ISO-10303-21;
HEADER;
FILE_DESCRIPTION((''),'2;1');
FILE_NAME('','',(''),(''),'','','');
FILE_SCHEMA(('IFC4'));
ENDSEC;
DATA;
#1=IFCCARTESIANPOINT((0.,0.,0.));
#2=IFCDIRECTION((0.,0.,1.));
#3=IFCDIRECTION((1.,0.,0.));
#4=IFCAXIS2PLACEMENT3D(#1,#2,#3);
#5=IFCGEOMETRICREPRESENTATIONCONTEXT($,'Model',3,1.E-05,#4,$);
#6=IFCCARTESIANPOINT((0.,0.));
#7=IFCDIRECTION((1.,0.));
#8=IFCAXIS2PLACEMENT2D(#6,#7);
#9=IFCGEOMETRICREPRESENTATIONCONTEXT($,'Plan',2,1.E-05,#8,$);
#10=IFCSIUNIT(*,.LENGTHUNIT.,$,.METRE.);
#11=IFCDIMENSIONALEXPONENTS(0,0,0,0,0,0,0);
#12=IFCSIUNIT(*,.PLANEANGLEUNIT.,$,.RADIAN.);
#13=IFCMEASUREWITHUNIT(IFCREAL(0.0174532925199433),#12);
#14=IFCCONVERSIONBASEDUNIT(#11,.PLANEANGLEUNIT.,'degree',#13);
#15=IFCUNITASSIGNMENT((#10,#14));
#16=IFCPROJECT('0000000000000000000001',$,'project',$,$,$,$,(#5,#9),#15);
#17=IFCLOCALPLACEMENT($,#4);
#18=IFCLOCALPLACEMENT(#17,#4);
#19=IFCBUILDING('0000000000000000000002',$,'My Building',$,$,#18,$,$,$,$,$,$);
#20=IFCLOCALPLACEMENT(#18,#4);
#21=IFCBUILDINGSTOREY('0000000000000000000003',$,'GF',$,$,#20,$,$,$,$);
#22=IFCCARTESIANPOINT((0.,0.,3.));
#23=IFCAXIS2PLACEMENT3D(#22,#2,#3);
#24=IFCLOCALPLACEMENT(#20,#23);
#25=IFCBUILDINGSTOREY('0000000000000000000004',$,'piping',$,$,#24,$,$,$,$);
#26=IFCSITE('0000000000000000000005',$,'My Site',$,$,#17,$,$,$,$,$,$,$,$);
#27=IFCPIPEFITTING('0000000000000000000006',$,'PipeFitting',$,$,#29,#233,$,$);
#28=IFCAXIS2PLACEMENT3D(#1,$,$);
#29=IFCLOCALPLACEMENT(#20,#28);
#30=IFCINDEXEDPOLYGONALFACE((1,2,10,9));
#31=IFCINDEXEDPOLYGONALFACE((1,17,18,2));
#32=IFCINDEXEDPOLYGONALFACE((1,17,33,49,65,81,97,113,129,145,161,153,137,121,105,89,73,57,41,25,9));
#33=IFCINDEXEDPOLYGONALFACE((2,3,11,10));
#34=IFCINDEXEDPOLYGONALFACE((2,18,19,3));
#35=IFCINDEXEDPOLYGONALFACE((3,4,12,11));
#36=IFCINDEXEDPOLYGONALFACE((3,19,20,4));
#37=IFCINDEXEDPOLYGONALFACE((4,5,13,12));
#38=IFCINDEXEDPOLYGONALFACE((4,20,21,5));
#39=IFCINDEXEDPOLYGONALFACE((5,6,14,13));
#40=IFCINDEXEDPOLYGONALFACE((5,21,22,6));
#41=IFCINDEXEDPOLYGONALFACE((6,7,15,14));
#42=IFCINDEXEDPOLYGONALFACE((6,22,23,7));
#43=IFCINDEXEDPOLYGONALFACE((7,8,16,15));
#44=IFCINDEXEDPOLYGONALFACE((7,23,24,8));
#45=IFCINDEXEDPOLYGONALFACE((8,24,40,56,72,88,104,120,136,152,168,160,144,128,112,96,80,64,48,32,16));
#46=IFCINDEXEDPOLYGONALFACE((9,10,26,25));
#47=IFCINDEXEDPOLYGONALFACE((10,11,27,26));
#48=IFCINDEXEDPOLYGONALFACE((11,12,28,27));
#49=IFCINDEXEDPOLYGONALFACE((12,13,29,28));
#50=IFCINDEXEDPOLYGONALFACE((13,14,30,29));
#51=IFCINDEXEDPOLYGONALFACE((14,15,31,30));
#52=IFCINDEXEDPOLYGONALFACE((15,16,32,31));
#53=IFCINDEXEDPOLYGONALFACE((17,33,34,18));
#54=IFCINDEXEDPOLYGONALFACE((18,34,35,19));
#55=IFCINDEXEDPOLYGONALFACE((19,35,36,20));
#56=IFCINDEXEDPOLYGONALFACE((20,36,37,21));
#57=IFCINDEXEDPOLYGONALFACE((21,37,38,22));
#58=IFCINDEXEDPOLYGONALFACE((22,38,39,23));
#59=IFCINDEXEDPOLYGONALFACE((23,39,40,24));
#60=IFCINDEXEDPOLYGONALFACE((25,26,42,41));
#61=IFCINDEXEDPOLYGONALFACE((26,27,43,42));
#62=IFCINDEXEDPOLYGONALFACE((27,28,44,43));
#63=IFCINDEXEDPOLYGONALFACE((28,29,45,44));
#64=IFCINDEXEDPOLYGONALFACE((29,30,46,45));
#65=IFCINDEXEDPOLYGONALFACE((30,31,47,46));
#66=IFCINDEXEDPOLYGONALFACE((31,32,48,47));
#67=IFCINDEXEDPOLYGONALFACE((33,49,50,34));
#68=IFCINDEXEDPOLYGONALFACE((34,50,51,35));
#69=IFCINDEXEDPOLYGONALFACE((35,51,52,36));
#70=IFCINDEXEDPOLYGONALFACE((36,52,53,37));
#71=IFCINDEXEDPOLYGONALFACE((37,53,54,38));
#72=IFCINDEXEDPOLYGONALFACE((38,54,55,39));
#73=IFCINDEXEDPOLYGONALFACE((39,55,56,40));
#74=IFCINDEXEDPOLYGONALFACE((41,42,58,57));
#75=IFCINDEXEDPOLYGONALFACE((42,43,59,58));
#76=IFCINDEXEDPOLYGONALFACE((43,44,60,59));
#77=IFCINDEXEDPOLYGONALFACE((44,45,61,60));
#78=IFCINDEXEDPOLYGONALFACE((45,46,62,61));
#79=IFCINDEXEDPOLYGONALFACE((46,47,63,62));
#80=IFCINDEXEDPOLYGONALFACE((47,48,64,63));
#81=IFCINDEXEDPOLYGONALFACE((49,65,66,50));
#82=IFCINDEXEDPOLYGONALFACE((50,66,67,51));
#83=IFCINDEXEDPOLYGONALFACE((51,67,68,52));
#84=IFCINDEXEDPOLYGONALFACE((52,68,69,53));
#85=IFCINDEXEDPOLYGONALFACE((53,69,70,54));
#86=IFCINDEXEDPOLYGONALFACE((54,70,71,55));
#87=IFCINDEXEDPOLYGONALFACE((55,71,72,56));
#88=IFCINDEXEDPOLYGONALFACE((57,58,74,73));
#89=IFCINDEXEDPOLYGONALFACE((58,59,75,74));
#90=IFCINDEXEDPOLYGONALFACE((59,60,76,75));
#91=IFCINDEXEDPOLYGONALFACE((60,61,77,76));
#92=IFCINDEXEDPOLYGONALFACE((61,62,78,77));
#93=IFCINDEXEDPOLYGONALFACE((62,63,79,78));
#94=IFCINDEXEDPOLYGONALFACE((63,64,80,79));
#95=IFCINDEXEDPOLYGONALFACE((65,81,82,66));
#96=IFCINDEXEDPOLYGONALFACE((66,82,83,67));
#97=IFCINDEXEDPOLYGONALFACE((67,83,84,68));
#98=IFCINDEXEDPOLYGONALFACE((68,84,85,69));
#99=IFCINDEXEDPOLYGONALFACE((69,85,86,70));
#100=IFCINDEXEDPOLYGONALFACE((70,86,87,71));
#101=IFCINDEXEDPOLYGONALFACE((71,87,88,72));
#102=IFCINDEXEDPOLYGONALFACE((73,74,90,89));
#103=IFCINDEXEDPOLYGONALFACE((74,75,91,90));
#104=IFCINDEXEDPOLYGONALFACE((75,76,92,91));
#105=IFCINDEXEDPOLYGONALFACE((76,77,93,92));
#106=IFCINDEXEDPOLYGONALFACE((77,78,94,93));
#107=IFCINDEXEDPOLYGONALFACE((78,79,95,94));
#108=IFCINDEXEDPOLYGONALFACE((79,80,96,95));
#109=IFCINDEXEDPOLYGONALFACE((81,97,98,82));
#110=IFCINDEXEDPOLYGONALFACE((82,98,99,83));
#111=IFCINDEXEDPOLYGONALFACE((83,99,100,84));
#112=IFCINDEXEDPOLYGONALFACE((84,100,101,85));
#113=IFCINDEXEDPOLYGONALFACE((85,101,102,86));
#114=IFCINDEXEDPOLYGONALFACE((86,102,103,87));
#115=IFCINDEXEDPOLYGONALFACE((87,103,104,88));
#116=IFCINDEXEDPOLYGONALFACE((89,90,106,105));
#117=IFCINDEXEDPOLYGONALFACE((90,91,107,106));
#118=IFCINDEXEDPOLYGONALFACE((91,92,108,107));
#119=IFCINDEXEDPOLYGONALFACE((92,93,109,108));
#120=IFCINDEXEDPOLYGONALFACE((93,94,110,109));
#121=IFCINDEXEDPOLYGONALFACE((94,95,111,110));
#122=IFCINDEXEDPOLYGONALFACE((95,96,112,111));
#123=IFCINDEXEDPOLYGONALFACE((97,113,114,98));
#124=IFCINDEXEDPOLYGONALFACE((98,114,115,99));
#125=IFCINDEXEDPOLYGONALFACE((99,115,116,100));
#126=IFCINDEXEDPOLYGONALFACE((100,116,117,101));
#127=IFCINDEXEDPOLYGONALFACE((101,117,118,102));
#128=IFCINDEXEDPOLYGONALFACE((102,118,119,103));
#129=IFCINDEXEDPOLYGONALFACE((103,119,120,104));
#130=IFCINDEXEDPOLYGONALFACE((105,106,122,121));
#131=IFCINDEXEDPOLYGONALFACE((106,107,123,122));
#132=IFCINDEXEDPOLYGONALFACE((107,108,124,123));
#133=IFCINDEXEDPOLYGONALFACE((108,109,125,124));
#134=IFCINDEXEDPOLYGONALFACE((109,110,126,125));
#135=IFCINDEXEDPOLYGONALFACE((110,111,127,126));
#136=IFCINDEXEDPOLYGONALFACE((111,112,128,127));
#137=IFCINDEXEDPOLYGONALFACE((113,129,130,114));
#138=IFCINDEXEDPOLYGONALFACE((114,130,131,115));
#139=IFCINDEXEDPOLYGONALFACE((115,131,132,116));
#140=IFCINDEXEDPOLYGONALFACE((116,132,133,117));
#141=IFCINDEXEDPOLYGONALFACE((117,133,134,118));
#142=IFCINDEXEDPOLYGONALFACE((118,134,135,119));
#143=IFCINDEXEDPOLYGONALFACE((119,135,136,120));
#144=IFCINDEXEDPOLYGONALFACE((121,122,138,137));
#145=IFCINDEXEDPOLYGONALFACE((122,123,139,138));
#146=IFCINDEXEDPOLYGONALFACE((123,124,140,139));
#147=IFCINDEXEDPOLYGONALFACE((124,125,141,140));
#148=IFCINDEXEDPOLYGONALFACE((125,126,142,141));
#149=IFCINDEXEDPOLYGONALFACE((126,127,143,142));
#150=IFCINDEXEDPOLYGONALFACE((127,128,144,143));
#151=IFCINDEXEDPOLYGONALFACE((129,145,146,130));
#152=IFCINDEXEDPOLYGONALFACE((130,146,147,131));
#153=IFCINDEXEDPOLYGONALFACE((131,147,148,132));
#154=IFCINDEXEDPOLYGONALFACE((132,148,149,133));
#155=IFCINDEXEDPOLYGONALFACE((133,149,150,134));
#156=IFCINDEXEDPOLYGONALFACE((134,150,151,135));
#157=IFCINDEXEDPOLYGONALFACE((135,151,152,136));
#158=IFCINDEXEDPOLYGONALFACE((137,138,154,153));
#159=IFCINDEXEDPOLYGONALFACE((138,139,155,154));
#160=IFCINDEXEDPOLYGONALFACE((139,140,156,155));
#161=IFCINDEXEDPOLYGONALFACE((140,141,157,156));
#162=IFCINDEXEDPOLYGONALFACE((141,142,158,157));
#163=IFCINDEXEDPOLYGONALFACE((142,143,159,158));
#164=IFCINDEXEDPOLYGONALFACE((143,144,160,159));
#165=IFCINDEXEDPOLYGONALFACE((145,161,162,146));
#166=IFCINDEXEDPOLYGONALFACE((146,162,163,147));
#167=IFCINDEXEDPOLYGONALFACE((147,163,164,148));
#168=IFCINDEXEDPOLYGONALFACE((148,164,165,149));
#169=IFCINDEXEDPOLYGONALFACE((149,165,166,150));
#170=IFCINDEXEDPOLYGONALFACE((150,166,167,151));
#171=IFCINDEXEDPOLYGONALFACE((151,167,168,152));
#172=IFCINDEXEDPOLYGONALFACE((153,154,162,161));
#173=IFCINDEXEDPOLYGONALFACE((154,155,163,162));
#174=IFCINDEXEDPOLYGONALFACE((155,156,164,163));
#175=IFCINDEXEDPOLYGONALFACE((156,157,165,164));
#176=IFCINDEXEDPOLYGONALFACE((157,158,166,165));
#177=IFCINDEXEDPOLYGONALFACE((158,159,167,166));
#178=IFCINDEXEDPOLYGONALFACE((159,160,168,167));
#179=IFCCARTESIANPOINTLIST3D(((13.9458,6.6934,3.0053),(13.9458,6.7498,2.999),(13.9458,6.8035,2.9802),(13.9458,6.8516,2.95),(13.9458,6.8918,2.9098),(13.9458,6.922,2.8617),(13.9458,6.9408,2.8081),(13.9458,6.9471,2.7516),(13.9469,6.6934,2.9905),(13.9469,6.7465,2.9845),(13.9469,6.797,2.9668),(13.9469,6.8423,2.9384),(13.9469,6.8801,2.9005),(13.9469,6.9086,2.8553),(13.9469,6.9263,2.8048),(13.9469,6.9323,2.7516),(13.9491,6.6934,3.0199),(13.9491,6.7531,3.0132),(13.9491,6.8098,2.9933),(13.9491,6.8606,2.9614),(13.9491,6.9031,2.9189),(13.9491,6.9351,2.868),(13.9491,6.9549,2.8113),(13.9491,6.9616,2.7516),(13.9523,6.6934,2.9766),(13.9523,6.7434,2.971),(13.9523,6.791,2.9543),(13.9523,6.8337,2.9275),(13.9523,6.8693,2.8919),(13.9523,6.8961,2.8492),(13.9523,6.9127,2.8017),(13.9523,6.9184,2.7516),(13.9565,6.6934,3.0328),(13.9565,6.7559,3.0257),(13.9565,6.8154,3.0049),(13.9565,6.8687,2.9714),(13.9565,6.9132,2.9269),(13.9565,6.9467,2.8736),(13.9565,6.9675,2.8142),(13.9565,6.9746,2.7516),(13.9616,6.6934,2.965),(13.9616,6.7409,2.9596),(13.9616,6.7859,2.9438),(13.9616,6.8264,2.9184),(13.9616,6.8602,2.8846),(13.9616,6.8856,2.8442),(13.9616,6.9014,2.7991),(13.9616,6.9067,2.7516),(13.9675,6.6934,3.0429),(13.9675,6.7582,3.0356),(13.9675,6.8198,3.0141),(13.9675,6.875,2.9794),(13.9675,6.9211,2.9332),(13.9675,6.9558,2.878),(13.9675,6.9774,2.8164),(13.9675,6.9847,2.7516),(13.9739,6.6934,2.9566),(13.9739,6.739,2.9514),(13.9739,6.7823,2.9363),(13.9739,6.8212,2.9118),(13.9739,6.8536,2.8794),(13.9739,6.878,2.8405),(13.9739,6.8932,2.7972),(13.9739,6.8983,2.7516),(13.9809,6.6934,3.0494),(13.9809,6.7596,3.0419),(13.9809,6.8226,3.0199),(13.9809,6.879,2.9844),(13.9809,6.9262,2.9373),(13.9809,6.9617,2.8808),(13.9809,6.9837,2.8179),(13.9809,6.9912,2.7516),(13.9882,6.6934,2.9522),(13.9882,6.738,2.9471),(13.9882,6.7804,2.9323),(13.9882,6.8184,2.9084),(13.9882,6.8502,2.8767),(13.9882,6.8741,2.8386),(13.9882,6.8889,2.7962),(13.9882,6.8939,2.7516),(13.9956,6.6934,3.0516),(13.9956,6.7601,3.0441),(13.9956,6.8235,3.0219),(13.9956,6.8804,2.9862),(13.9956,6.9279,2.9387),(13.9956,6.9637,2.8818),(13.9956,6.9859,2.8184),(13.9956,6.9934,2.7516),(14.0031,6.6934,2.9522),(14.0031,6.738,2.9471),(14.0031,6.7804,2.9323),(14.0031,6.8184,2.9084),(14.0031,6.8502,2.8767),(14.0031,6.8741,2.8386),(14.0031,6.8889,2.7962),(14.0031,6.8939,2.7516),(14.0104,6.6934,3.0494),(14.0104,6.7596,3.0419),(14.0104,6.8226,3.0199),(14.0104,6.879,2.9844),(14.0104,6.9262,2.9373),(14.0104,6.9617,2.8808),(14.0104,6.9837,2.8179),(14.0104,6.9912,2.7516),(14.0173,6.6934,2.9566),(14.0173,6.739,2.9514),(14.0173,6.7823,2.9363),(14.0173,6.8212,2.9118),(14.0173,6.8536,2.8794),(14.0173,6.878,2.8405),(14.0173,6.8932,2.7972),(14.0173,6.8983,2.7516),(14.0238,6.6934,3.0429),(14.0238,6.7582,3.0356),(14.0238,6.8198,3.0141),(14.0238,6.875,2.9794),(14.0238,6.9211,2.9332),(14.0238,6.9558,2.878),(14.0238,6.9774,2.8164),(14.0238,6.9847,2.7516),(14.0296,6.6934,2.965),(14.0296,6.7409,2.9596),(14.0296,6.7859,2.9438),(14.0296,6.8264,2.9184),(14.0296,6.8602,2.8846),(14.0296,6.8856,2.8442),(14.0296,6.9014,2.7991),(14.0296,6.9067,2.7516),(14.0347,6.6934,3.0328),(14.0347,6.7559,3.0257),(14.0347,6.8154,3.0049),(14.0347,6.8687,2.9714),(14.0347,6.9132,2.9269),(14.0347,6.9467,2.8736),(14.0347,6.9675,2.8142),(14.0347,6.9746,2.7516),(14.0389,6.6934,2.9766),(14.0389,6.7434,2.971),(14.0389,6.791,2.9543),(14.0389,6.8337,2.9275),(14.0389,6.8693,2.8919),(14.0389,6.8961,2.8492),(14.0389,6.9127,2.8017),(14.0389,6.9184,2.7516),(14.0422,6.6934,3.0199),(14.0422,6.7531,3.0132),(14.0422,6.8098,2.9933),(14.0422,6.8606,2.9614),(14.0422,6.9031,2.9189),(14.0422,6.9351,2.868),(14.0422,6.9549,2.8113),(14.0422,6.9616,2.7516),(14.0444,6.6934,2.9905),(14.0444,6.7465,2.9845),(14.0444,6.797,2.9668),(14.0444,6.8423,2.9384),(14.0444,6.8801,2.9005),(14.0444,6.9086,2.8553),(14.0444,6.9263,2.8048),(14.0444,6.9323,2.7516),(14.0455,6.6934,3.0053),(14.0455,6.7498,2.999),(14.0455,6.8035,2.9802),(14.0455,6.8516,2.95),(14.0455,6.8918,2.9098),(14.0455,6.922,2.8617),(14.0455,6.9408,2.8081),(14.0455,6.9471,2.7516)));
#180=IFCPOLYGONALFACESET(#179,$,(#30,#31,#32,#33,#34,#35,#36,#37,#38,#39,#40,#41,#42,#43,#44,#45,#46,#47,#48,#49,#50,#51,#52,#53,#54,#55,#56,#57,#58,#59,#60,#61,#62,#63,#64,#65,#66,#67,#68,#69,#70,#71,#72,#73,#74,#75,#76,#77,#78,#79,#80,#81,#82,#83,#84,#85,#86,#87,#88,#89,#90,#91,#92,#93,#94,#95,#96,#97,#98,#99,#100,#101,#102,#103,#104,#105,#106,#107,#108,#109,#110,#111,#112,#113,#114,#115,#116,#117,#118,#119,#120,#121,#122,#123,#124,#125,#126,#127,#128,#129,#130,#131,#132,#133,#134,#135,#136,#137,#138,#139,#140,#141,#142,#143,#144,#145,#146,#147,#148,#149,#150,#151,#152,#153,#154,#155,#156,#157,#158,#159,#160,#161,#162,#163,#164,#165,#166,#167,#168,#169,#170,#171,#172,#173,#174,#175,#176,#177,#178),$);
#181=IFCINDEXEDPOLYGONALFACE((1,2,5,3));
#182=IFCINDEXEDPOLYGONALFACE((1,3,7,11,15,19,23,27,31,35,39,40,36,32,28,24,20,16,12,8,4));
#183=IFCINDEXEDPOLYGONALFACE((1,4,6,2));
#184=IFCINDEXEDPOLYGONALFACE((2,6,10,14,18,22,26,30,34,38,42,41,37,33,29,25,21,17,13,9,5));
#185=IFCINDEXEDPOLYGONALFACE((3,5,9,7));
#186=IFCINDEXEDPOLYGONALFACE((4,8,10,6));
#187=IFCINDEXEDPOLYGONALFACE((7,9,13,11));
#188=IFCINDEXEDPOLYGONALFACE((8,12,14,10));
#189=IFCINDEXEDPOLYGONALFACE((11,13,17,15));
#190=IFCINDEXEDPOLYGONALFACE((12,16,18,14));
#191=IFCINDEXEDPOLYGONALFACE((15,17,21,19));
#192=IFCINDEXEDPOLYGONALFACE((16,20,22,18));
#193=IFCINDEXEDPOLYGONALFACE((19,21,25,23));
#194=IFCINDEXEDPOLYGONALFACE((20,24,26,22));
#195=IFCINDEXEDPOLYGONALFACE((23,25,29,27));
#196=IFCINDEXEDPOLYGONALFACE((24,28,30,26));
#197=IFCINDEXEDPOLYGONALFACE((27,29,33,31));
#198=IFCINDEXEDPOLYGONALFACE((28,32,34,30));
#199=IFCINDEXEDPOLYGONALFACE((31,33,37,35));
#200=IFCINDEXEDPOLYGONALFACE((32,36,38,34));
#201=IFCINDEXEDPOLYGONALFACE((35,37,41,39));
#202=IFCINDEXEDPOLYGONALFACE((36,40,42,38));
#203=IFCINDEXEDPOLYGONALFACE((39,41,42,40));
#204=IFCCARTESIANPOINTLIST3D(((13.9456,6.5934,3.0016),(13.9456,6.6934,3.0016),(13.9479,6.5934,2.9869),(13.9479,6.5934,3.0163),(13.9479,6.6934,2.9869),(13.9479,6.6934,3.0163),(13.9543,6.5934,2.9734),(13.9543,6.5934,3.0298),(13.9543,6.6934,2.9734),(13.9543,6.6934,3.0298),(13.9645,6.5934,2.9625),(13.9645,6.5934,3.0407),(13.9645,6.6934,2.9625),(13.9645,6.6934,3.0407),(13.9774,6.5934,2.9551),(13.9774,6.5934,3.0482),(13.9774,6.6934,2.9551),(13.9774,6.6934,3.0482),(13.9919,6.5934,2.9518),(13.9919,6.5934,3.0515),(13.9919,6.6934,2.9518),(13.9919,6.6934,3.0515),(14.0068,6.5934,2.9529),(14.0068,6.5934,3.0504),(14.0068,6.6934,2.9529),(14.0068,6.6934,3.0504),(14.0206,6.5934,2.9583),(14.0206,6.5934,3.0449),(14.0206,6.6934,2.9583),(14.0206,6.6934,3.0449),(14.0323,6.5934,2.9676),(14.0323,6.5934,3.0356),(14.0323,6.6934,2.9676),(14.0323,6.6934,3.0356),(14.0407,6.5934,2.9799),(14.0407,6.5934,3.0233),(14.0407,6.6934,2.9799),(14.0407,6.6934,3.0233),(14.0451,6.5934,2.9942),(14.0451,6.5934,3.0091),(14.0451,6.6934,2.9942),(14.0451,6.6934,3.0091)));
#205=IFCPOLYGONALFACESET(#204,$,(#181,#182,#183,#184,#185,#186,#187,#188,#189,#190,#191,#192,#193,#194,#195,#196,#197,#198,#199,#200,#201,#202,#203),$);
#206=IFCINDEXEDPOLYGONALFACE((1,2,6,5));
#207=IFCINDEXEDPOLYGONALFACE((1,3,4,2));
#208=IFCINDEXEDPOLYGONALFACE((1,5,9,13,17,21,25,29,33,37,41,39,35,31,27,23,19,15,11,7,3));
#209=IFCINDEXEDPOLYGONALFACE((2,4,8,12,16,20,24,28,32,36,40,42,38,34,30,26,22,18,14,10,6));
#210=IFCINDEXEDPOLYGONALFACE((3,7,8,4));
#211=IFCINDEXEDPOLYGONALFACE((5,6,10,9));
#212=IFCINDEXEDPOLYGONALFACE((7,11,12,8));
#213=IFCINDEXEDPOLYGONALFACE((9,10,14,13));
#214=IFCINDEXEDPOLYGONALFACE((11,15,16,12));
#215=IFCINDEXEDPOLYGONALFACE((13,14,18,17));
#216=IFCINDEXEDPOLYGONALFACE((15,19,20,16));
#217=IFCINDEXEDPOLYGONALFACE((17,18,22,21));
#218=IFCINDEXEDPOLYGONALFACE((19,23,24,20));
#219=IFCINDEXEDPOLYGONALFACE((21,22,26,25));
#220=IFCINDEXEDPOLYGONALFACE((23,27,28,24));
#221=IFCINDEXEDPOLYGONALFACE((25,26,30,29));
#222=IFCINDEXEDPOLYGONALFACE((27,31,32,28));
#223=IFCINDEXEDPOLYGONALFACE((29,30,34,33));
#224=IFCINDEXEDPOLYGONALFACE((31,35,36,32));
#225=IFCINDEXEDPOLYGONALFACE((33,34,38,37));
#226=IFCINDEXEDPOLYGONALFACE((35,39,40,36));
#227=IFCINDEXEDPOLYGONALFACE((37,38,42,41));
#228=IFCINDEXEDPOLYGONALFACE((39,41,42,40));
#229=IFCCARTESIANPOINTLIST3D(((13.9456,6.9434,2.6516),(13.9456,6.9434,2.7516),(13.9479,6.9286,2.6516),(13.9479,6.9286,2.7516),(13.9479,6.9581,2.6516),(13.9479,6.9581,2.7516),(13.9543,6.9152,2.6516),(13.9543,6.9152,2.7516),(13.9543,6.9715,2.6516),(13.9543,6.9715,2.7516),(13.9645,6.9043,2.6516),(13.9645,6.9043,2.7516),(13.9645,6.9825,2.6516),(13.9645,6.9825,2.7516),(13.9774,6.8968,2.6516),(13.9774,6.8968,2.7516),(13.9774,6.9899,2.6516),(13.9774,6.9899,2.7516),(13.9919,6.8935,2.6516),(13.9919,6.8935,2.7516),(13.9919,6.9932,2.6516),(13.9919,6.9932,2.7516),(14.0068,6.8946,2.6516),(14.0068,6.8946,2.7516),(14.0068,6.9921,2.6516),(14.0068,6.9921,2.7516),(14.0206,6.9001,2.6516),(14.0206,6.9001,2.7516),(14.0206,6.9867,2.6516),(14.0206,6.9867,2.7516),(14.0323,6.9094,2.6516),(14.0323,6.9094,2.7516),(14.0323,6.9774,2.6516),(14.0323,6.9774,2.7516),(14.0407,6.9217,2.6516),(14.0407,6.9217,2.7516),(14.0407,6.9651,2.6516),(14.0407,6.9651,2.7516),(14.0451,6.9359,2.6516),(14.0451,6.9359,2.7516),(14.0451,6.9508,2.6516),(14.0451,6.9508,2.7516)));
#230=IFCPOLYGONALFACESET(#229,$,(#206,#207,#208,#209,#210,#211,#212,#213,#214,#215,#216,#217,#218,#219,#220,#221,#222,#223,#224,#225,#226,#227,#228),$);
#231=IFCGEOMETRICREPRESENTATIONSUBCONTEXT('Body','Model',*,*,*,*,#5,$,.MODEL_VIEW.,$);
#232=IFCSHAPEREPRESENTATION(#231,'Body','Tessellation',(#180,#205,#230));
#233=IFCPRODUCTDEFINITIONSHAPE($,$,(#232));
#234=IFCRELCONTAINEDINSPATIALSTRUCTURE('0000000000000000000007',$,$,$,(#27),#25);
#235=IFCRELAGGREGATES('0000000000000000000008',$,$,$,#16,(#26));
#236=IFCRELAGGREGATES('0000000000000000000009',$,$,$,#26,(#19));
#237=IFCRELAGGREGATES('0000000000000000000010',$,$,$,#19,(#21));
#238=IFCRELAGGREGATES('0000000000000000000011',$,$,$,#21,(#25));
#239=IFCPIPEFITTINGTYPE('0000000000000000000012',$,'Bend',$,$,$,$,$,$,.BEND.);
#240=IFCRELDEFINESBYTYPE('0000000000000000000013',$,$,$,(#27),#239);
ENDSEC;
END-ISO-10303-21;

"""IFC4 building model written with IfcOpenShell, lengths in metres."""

from ifc_helpers import new_model, entity, si_unit, converted_unit, frame, origin_with_axes, origin_2d_with_axis, place, context, subcontext, project, spatial, circle, extrude, source, transform, mapped, type_object, type_shapes, element, save


model = new_model("IFC4")

# Units and contexts
model_context = context("Model", 3, precision=1e-05, world=origin_with_axes())
plan_context = context("Plan", 2, precision=1e-05, world=origin_2d_with_axis())
body_context = subcontext(model_context, "Body", "Model", "MODEL_VIEW")
ifc_project = project(units=[si_unit("LENGTHUNIT", "METRE"), converted_unit("PLANEANGLEUNIT", "degree", entity("IfcReal", 0.0174532925199433), si_unit("PLANEANGLEUNIT", "RADIAN"), dimensions=[0, 0, 0, 0, 0, 0, 0])], contexts=[model_context, plan_context])

# Site, building, storeys
site_placement = place(None, origin_with_axes())
site = spatial("IfcSite", under=ifc_project, at=site_placement, Name="My Site")
building_placement = place(site_placement, origin_with_axes())
building = spatial("IfcBuilding", under=site, at=building_placement, Name="My Building")
storey_1_placement = place(building_placement, origin_with_axes())
storey_1 = spatial("IfcBuildingStorey", under=building, at=storey_1_placement, Name="GF")
storey_2_placement = place(storey_1_placement, frame((0.0, 0.0, 3.0), z_axis=(0.0, 0.0, 1.0), x_axis=(1.0, 0.0, 0.0)))
storey_2 = spatial("IfcBuildingStorey", under=storey_1, at=storey_2_placement, Name="piping")

# Pipe fitting
pipe_fitting_type = type_object("IfcPipeFittingType", Name="Bend", PredefinedType="BEND")
shared_shape = source(origin_with_axes(), body_context, "Body", "SolidModel", [
    entity("IfcSweptDiskSolid", entity("IfcIndexedPolyCurve", entity("IfcCartesianPointList3D", [[0.0, 0.0, -0.1], [0.0, 0.0732, -0.2768], [0.0, 0.25, -0.35]]), [entity("IfcArcIndex", [1, 2, 3])]), 0.05),
    extrude(circle(Radius=0.05), origin_with_axes(), (0.0, 0.0, -1.0), 0.1),
    extrude(circle(Radius=0.05), frame((0.0, 0.25, -0.35), z_axis=(0.0, 1.0, 0.0), x_axis=(1.0, 0.0, 0.0)), (0.0, 0.0, 1.0), 0.1),
])
type_shapes(pipe_fitting_type, [shared_shape])
for number, where, z_axis, x_axis, name in (
    (1, (13.9956, 6.5934, 0.0016), (0.0, -1.0, 0.0), (-1.0, 0.0, 0.0), "PipeFitting"),
):
    element("IfcPipeFitting", number, at=place(storey_2_placement, frame(where, z_axis=z_axis, x_axis=x_axis)), inside=storey_2, type_object=pipe_fitting_type, Name=name, context=body_context, shape_type="MappedRepresentation", body=[
        mapped(shared_shape, transform((0.0, 0.0, 0.0), x_axis=(1.0, 0.0, 0.0), y_axis=(0.0, 1.0, 0.0), z_axis=(0.0, 0.0, 1.0), scale=1.0)),
    ])

save(model, "model.ifc")
